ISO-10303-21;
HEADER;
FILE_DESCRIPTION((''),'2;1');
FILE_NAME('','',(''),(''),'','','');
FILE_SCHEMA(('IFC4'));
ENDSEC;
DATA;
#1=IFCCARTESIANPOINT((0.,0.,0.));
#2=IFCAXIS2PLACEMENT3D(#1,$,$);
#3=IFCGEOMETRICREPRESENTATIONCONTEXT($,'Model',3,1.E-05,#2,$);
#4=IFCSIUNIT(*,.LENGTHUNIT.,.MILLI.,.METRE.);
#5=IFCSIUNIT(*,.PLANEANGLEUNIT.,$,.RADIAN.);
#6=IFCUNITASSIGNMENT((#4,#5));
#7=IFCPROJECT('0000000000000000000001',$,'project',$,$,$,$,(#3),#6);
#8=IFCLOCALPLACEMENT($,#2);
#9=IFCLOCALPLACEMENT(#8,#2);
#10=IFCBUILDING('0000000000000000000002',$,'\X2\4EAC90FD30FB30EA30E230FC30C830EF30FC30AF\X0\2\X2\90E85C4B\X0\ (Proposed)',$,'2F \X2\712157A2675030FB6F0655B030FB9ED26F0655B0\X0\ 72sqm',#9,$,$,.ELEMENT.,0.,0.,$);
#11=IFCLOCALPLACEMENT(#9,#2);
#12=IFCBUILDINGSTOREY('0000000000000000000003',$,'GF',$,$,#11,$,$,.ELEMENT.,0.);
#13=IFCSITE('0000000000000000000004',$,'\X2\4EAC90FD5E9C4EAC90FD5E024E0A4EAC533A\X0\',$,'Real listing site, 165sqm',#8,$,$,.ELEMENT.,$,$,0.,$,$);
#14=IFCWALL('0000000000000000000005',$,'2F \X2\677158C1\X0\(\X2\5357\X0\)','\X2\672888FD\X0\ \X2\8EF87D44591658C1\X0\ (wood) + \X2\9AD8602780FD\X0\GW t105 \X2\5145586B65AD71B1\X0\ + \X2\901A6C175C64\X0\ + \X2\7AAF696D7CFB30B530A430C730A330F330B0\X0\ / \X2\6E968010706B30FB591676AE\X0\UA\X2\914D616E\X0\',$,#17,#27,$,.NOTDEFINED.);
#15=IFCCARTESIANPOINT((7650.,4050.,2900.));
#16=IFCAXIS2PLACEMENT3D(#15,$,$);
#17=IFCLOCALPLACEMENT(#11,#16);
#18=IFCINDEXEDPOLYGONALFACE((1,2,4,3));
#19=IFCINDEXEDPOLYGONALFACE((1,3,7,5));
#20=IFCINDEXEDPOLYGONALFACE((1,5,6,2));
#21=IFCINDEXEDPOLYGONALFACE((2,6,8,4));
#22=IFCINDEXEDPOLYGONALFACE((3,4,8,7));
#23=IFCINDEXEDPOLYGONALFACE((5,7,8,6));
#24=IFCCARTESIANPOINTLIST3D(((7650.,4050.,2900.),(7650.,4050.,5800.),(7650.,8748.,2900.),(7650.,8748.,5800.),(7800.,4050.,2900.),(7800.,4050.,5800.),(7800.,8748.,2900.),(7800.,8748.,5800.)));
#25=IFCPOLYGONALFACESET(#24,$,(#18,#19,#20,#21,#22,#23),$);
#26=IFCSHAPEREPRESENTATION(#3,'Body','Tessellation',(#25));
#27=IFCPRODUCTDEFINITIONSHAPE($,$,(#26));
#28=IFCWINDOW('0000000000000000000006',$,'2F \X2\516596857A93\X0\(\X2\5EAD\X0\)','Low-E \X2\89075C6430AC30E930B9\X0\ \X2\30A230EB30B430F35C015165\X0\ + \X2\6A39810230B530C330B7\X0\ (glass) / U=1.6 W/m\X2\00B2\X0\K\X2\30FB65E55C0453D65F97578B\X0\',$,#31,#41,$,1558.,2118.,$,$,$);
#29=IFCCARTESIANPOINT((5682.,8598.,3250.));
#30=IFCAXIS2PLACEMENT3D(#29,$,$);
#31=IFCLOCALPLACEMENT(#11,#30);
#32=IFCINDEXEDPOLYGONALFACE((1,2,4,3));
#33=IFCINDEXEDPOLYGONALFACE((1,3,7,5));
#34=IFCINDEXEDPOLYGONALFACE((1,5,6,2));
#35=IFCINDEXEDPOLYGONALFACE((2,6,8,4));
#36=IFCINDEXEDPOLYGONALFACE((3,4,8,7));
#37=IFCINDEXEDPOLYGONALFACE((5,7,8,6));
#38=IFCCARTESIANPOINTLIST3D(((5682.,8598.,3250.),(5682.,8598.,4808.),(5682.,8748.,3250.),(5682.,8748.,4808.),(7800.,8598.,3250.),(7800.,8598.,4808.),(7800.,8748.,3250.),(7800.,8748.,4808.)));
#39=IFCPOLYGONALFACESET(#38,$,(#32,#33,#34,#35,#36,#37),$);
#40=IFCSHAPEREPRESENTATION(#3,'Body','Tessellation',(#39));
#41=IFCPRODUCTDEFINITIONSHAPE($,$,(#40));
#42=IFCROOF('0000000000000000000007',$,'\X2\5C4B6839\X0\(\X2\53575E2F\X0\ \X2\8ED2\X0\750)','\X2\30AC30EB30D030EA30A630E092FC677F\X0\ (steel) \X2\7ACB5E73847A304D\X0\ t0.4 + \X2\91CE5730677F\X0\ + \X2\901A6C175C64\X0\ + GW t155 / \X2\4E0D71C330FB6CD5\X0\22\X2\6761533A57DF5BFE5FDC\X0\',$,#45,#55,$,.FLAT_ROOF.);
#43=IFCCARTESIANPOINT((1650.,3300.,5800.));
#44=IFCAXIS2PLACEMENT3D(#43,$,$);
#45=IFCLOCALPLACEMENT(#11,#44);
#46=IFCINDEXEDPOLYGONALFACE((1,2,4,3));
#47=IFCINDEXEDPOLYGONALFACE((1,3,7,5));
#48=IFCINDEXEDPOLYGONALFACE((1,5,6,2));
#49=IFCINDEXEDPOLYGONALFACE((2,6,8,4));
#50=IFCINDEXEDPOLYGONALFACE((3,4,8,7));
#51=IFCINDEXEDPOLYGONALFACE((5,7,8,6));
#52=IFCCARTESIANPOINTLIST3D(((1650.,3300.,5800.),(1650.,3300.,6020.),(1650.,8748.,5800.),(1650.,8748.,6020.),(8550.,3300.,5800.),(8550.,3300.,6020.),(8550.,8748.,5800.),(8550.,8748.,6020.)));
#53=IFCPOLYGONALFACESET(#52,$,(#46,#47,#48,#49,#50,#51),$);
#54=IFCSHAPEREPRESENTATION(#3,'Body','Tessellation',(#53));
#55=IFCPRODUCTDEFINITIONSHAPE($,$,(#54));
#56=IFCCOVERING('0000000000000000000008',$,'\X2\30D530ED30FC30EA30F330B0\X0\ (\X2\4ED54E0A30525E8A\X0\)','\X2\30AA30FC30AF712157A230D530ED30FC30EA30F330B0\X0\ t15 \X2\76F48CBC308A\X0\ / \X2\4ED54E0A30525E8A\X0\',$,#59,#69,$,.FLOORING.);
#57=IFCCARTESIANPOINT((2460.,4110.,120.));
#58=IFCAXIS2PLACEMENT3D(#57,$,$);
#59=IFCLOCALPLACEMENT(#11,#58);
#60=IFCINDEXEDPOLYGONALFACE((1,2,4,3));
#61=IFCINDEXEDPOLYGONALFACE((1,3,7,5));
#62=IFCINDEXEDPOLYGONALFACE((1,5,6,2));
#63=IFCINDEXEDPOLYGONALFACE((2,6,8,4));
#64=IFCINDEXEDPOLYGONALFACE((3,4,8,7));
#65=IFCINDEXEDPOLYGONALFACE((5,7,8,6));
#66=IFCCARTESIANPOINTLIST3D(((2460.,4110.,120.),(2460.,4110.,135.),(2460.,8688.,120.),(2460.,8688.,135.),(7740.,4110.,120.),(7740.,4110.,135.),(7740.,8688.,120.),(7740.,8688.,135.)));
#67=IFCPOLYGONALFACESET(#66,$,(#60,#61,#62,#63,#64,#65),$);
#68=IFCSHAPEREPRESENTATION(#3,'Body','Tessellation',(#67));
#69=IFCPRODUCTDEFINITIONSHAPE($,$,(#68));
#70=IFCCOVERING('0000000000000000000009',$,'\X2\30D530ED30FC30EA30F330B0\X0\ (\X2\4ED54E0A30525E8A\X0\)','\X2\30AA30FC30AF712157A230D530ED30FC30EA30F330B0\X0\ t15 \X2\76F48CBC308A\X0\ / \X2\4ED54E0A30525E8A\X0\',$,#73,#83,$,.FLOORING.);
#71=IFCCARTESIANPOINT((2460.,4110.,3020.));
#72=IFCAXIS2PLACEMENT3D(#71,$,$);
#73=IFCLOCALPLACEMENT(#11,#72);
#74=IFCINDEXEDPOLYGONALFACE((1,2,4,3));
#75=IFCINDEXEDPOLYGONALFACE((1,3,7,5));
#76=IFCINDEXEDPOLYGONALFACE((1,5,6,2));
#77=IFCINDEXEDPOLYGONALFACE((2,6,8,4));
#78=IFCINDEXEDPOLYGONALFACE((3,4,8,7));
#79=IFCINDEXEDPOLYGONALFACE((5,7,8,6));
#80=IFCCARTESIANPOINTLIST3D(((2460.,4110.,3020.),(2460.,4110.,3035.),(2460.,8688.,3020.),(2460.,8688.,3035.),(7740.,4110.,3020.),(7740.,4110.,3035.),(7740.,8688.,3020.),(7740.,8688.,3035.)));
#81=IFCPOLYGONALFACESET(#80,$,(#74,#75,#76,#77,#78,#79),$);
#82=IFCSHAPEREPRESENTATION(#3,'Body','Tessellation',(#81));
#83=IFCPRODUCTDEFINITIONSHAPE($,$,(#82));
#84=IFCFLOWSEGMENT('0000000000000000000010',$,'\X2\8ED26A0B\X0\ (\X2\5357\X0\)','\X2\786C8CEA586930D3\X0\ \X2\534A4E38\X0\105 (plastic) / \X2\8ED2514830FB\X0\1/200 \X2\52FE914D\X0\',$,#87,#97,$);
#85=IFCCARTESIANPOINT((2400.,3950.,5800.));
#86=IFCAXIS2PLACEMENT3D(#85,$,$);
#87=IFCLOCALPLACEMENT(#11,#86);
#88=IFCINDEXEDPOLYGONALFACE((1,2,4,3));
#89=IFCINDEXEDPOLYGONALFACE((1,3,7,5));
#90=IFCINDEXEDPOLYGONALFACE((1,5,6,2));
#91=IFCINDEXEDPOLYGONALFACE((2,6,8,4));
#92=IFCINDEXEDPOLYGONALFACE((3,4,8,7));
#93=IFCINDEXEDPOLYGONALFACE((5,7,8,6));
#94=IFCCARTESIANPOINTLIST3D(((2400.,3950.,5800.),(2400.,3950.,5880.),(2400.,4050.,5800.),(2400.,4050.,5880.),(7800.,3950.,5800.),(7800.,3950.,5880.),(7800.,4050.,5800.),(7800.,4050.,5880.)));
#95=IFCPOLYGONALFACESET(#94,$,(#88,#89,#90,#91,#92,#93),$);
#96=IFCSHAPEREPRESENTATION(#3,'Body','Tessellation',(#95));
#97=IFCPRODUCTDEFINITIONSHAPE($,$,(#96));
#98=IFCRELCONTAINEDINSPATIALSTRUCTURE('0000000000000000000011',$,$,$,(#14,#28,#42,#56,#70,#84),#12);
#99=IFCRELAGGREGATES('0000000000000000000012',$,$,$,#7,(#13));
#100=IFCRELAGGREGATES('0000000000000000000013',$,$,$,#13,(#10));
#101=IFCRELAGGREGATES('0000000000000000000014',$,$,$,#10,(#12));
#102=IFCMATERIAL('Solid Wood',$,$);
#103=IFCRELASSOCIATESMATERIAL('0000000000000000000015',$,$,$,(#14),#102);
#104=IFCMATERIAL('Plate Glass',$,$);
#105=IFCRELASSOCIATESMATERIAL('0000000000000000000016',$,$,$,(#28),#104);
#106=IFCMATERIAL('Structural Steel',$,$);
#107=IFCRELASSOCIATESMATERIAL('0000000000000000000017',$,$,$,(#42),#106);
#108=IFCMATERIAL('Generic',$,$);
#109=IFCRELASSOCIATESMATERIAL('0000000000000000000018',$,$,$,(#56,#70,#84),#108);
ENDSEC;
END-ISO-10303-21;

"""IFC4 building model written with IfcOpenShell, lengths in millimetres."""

from ifc_helpers import new_model, si_unit, frame, frame_2d, origin, place, context, project, spatial, rectangle, extrude, material, element, fill, save


model = new_model("IFC4")

# Units and contexts
model_context = context("Model", 3, precision=1e-05, world=origin())
ifc_project = project(units=[si_unit("LENGTHUNIT", "METRE", prefix="MILLI"), si_unit("PLANEANGLEUNIT", "RADIAN")], contexts=[model_context])

# Site, building, storey
site_placement = place(None, origin())
site = spatial("IfcSite", under=ifc_project, at=site_placement, Name="京都府京都市上京区", ObjectType="Real listing site, 165sqm", CompositionType="ELEMENT", RefElevation=0.0)
building_placement = place(site_placement, origin())
building = spatial("IfcBuilding", under=site, at=building_placement, Name="京都・リモートワーク2部屋 (Proposed)", ObjectType="2F 無垢材・漆喰・黒漆喰 72sqm", CompositionType="ELEMENT", ElevationOfRefHeight=0.0, ElevationOfTerrain=0.0)
storey_placement = place(building_placement, origin())
storey = spatial("IfcBuildingStorey", under=building, at=storey_placement, Name="GF", CompositionType="ELEMENT", Elevation=0.0)

# Shared definitions
ifc_material_1 = material(Name="Solid Wood")

# Wall, opening, window
ifc_material_2 = material(Name="Plate Glass")
wall_1_placement = place(storey_placement, frame((7650.0, 4050.0, 2900.0)))
wall_1 = element("IfcWall", 1, at=wall_1_placement, inside=storey, material=ifc_material_1, Name="2F 東壁(南)", Description="木製 軸組外壁 (wood) + 高性能GW t105 充填断熱 + 通気層 + 窯業系サイディング / 準耐火・外皮UA配慮", PredefinedType="NOTDEFINED", context=model_context, shape_type="SweptSolid", body=[
    extrude(rectangle(XDim=150.0, YDim=4698.0, at=frame_2d((75.0, 2349.0))), frame((7650.0, 4050.0, 2900.0)), (0.0, 0.0, 1.0), 2900.0),
])
opening_1_placement = place(storey_placement, frame((5682.0, 8598.0, 3250.0)))
opening_1 = element("IfcOpeningElement", 2, at=opening_1_placement, cuts=wall_1, PredefinedType="NOTDEFINED", context=model_context, shape_type="SweptSolid", body=[
    extrude(rectangle(XDim=2118.0, YDim=150.0, at=frame_2d((1059.0, 75.0))), frame((5682.0, 8598.0, 3250.0)), (0.0, 0.0, 1.0), 1558.0),
])
window_1_placement = place(storey_placement, frame((5682.0, 8598.0, 3250.0)))
window_1 = element("IfcWindow", 3, at=window_1_placement, inside=storey, material=ifc_material_2, Name="2F 入隅窓(庭)", Description="Low-E 複層ガラス アルゴン封入 + 樹脂サッシ (glass) / U=1.6 W/m²K・日射取得型", OverallHeight=1558.0, OverallWidth=2118.0, context=model_context, shape_type="SweptSolid", body=[
    extrude(rectangle(XDim=2118.0, YDim=150.0, at=frame_2d((1059.0, 75.0))), frame((5682.0, 8598.0, 3250.0)), (0.0, 0.0, 1.0), 1558.0),
])
fill(opening_1, window_1)

# Roof
ifc_material_3 = material(Name="Structural Steel")
for number, where, name in (
    (4, (1650.0, 3300.0, 5800.0), "屋根(南帯 軒750)"),
):
    element("IfcRoof", number, at=place(storey_placement, frame(where)), inside=storey, material=ifc_material_3, Name=name, Description="ガルバリウム鋼板 (steel) 立平葺き t0.4 + 野地板 + 通気層 + GW t155 / 不燃・法22条区域対応", PredefinedType="FLAT_ROOF", context=model_context, shape_type="SweptSolid", body=[
        extrude(rectangle(XDim=6900.0, YDim=5448.0, at=frame_2d((3450.0, 2724.0))), frame((1650.0, 3300.0, 5800.0)), (0.0, 0.0, 1.0), 220.0),
    ])

# Coverings
ifc_material_4 = material(Name="Generic")
covering_1_placement = place(storey_placement, frame((2460.0, 4110.0, 120.0)))
element("IfcCovering", 5, at=covering_1_placement, inside=storey, material=ifc_material_4, Name="フローリング (仕上げ床)", Description="オーク無垢フローリング t15 直貼り / 仕上げ床", PredefinedType="FLOORING", context=model_context, shape_type="SweptSolid", body=[
    extrude(rectangle(XDim=5280.0, YDim=4578.0, at=frame_2d((2640.0, 2289.0))), frame((2460.0, 4110.0, 120.0)), (0.0, 0.0, 1.0), 15.0),
])
covering_2_placement = place(storey_placement, frame((2460.0, 4110.0, 3020.0)))
element("IfcCovering", 6, at=covering_2_placement, inside=storey, material=ifc_material_4, Name="フローリング (仕上げ床)", Description="オーク無垢フローリング t15 直貼り / 仕上げ床", PredefinedType="FLOORING", context=model_context, shape_type="SweptSolid", body=[
    extrude(rectangle(XDim=5280.0, YDim=4578.0, at=frame_2d((2640.0, 2289.0))), frame((2460.0, 4110.0, 3020.0)), (0.0, 0.0, 1.0), 15.0),
])

# Flow segment
flow_segment_placement = place(storey_placement, frame((2400.0, 3950.0, 5800.0)))
element("IfcFlowSegment", 7, at=flow_segment_placement, inside=storey, material=ifc_material_4, Name="軒樋 (南)", Description="硬質塩ビ 半丸105 (plastic) / 軒先・1/200 勾配", context=model_context, shape_type="SweptSolid", body=[
    extrude(rectangle(XDim=5400.0, YDim=100.0, at=frame_2d((2700.0, 50.0))), frame((2400.0, 3950.0, 5800.0)), (0.0, 0.0, 1.0), 80.0),
])

save(model, "model.ifc")
